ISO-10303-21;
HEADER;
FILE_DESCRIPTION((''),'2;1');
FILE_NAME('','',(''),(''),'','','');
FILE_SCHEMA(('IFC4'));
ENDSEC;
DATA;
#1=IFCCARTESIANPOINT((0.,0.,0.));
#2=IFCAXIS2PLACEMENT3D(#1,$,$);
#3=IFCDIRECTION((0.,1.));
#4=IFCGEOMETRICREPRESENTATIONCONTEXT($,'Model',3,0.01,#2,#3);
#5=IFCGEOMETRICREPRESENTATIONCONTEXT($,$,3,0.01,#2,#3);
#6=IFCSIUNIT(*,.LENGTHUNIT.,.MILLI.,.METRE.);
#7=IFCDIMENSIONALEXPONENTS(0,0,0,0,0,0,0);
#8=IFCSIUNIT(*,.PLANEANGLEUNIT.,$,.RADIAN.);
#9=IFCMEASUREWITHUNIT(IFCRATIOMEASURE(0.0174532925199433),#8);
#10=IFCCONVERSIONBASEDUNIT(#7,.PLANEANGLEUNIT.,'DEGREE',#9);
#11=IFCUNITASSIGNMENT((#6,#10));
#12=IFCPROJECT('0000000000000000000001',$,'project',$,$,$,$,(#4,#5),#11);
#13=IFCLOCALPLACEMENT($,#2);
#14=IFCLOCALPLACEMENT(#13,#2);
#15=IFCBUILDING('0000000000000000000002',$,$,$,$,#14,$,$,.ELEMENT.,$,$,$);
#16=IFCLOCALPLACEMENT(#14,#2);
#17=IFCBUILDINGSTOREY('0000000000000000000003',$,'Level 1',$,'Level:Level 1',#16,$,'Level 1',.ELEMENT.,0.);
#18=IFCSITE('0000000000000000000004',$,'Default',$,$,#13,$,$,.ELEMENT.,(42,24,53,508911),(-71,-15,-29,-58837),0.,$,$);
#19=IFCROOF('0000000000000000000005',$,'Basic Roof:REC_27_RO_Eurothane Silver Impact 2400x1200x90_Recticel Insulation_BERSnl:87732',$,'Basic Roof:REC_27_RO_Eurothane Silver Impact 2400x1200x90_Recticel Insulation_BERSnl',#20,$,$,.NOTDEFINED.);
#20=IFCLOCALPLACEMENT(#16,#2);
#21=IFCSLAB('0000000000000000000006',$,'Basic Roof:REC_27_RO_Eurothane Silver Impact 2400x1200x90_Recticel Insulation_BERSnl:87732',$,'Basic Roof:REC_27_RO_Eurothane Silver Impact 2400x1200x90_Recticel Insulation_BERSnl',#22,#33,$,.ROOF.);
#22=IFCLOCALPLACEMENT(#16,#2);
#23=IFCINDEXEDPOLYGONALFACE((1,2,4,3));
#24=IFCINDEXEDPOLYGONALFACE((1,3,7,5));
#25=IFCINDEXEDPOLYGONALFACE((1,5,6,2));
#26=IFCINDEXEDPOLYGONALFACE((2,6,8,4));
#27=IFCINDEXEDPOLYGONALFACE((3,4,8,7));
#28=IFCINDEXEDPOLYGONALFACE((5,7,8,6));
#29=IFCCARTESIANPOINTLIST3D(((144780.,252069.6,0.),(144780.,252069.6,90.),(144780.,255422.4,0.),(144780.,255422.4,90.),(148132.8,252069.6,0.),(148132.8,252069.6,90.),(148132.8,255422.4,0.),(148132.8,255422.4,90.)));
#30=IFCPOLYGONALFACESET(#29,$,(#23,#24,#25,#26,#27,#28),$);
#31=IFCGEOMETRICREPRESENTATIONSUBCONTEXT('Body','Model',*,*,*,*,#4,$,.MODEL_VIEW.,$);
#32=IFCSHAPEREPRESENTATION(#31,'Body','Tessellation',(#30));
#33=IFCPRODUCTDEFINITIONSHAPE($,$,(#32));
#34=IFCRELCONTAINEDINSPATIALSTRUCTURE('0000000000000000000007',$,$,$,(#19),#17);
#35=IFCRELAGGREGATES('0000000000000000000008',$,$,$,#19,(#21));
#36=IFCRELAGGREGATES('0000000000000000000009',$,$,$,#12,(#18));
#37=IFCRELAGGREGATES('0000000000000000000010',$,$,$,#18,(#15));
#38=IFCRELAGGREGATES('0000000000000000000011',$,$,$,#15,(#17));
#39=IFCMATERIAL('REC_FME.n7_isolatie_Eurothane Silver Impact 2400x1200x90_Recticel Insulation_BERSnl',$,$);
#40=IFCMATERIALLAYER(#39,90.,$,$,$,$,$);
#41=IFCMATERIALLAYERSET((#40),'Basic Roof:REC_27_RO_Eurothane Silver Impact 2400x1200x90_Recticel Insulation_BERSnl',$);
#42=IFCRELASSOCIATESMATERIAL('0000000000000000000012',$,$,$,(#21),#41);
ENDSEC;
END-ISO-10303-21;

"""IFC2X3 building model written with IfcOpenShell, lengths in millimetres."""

from ifc_helpers import new_model, entity, si_unit, converted_unit, direction, frame, frame_2d, origin, place, context, subcontext, project, spatial, rectangle, extrude, material, layer, layer_set, element, aggregate, save


model = new_model("IFC2X3")

# Units and contexts
model_context = context("Model", 3, precision=0.01, world=origin(), true_north=direction((0.0, 1.0)))
context_of_model = context(None, 3, precision=0.01, world=origin(), true_north=direction((0.0, 1.0)))
body_context = subcontext(model_context, "Body", "Model", "MODEL_VIEW")
ifc_project = project(units=[si_unit("LENGTHUNIT", "METRE", prefix="MILLI"), converted_unit("PLANEANGLEUNIT", "DEGREE", entity("IfcRatioMeasure", 0.0174532925199433), si_unit("PLANEANGLEUNIT", "RADIAN"), dimensions=[0, 0, 0, 0, 0, 0, 0])], contexts=[model_context, context_of_model])

# Site, building, storey
site_placement = place(None, origin())
site = spatial("IfcSite", under=ifc_project, at=site_placement, Name="Default", CompositionType="ELEMENT", RefLatitude=(42, 24, 53, 508911), RefLongitude=(-71, -15, -29, -58837), RefElevation=0.0)
building_placement = place(site_placement, origin())
building = spatial("IfcBuilding", under=site, at=building_placement, CompositionType="ELEMENT")
storey_placement = place(building_placement, origin())
storey = spatial("IfcBuildingStorey", under=building, at=storey_placement, Name="Level 1", ObjectType="Level:Level 1", LongName="Level 1", CompositionType="ELEMENT", Elevation=0.0)

# Roof, slab
roof_1_placement = place(storey_placement, frame((144780.0, 252069.6, 0.0)))
roof_1 = element("IfcRoof", 1, at=roof_1_placement, inside=storey, Name="Basic Roof:REC_27_RO_Eurothane Silver Impact 2400x1200x90_Recticel Insulation_BERSnl:87732", ObjectType="Basic Roof:REC_27_RO_Eurothane Silver Impact 2400x1200x90_Recticel Insulation_BERSnl", ShapeType="NOTDEFINED")
ifc_material_1 = material(Name="REC_FME.n7_isolatie_Eurothane Silver Impact 2400x1200x90_Recticel Insulation_BERSnl")
ifc_layer_1 = layer(ifc_material_1, 90.0)
ifc_layer_set_1 = layer_set([ifc_layer_1], Name="Basic Roof:REC_27_RO_Eurothane Silver Impact 2400x1200x90_Recticel Insulation_BERSnl")
slab_1_placement = place(roof_1_placement, origin())
slab_1 = element("IfcSlab", 2, at=slab_1_placement, material=ifc_layer_set_1, Name="Basic Roof:REC_27_RO_Eurothane Silver Impact 2400x1200x90_Recticel Insulation_BERSnl:87732", ObjectType="Basic Roof:REC_27_RO_Eurothane Silver Impact 2400x1200x90_Recticel Insulation_BERSnl", PredefinedType="ROOF", context=body_context, shape_type="SweptSolid", body=[
    extrude(rectangle(XDim=3352.8, YDim=3352.8, at=frame_2d((0.0, 0.0), x_axis=(-1.0, 0.0))), frame((1676.4, 1676.4, 0.0)), (0.0, 0.0, 1.0), 90.0),
])
aggregate(roof_1, [slab_1])

save(model, "model.ifc")
